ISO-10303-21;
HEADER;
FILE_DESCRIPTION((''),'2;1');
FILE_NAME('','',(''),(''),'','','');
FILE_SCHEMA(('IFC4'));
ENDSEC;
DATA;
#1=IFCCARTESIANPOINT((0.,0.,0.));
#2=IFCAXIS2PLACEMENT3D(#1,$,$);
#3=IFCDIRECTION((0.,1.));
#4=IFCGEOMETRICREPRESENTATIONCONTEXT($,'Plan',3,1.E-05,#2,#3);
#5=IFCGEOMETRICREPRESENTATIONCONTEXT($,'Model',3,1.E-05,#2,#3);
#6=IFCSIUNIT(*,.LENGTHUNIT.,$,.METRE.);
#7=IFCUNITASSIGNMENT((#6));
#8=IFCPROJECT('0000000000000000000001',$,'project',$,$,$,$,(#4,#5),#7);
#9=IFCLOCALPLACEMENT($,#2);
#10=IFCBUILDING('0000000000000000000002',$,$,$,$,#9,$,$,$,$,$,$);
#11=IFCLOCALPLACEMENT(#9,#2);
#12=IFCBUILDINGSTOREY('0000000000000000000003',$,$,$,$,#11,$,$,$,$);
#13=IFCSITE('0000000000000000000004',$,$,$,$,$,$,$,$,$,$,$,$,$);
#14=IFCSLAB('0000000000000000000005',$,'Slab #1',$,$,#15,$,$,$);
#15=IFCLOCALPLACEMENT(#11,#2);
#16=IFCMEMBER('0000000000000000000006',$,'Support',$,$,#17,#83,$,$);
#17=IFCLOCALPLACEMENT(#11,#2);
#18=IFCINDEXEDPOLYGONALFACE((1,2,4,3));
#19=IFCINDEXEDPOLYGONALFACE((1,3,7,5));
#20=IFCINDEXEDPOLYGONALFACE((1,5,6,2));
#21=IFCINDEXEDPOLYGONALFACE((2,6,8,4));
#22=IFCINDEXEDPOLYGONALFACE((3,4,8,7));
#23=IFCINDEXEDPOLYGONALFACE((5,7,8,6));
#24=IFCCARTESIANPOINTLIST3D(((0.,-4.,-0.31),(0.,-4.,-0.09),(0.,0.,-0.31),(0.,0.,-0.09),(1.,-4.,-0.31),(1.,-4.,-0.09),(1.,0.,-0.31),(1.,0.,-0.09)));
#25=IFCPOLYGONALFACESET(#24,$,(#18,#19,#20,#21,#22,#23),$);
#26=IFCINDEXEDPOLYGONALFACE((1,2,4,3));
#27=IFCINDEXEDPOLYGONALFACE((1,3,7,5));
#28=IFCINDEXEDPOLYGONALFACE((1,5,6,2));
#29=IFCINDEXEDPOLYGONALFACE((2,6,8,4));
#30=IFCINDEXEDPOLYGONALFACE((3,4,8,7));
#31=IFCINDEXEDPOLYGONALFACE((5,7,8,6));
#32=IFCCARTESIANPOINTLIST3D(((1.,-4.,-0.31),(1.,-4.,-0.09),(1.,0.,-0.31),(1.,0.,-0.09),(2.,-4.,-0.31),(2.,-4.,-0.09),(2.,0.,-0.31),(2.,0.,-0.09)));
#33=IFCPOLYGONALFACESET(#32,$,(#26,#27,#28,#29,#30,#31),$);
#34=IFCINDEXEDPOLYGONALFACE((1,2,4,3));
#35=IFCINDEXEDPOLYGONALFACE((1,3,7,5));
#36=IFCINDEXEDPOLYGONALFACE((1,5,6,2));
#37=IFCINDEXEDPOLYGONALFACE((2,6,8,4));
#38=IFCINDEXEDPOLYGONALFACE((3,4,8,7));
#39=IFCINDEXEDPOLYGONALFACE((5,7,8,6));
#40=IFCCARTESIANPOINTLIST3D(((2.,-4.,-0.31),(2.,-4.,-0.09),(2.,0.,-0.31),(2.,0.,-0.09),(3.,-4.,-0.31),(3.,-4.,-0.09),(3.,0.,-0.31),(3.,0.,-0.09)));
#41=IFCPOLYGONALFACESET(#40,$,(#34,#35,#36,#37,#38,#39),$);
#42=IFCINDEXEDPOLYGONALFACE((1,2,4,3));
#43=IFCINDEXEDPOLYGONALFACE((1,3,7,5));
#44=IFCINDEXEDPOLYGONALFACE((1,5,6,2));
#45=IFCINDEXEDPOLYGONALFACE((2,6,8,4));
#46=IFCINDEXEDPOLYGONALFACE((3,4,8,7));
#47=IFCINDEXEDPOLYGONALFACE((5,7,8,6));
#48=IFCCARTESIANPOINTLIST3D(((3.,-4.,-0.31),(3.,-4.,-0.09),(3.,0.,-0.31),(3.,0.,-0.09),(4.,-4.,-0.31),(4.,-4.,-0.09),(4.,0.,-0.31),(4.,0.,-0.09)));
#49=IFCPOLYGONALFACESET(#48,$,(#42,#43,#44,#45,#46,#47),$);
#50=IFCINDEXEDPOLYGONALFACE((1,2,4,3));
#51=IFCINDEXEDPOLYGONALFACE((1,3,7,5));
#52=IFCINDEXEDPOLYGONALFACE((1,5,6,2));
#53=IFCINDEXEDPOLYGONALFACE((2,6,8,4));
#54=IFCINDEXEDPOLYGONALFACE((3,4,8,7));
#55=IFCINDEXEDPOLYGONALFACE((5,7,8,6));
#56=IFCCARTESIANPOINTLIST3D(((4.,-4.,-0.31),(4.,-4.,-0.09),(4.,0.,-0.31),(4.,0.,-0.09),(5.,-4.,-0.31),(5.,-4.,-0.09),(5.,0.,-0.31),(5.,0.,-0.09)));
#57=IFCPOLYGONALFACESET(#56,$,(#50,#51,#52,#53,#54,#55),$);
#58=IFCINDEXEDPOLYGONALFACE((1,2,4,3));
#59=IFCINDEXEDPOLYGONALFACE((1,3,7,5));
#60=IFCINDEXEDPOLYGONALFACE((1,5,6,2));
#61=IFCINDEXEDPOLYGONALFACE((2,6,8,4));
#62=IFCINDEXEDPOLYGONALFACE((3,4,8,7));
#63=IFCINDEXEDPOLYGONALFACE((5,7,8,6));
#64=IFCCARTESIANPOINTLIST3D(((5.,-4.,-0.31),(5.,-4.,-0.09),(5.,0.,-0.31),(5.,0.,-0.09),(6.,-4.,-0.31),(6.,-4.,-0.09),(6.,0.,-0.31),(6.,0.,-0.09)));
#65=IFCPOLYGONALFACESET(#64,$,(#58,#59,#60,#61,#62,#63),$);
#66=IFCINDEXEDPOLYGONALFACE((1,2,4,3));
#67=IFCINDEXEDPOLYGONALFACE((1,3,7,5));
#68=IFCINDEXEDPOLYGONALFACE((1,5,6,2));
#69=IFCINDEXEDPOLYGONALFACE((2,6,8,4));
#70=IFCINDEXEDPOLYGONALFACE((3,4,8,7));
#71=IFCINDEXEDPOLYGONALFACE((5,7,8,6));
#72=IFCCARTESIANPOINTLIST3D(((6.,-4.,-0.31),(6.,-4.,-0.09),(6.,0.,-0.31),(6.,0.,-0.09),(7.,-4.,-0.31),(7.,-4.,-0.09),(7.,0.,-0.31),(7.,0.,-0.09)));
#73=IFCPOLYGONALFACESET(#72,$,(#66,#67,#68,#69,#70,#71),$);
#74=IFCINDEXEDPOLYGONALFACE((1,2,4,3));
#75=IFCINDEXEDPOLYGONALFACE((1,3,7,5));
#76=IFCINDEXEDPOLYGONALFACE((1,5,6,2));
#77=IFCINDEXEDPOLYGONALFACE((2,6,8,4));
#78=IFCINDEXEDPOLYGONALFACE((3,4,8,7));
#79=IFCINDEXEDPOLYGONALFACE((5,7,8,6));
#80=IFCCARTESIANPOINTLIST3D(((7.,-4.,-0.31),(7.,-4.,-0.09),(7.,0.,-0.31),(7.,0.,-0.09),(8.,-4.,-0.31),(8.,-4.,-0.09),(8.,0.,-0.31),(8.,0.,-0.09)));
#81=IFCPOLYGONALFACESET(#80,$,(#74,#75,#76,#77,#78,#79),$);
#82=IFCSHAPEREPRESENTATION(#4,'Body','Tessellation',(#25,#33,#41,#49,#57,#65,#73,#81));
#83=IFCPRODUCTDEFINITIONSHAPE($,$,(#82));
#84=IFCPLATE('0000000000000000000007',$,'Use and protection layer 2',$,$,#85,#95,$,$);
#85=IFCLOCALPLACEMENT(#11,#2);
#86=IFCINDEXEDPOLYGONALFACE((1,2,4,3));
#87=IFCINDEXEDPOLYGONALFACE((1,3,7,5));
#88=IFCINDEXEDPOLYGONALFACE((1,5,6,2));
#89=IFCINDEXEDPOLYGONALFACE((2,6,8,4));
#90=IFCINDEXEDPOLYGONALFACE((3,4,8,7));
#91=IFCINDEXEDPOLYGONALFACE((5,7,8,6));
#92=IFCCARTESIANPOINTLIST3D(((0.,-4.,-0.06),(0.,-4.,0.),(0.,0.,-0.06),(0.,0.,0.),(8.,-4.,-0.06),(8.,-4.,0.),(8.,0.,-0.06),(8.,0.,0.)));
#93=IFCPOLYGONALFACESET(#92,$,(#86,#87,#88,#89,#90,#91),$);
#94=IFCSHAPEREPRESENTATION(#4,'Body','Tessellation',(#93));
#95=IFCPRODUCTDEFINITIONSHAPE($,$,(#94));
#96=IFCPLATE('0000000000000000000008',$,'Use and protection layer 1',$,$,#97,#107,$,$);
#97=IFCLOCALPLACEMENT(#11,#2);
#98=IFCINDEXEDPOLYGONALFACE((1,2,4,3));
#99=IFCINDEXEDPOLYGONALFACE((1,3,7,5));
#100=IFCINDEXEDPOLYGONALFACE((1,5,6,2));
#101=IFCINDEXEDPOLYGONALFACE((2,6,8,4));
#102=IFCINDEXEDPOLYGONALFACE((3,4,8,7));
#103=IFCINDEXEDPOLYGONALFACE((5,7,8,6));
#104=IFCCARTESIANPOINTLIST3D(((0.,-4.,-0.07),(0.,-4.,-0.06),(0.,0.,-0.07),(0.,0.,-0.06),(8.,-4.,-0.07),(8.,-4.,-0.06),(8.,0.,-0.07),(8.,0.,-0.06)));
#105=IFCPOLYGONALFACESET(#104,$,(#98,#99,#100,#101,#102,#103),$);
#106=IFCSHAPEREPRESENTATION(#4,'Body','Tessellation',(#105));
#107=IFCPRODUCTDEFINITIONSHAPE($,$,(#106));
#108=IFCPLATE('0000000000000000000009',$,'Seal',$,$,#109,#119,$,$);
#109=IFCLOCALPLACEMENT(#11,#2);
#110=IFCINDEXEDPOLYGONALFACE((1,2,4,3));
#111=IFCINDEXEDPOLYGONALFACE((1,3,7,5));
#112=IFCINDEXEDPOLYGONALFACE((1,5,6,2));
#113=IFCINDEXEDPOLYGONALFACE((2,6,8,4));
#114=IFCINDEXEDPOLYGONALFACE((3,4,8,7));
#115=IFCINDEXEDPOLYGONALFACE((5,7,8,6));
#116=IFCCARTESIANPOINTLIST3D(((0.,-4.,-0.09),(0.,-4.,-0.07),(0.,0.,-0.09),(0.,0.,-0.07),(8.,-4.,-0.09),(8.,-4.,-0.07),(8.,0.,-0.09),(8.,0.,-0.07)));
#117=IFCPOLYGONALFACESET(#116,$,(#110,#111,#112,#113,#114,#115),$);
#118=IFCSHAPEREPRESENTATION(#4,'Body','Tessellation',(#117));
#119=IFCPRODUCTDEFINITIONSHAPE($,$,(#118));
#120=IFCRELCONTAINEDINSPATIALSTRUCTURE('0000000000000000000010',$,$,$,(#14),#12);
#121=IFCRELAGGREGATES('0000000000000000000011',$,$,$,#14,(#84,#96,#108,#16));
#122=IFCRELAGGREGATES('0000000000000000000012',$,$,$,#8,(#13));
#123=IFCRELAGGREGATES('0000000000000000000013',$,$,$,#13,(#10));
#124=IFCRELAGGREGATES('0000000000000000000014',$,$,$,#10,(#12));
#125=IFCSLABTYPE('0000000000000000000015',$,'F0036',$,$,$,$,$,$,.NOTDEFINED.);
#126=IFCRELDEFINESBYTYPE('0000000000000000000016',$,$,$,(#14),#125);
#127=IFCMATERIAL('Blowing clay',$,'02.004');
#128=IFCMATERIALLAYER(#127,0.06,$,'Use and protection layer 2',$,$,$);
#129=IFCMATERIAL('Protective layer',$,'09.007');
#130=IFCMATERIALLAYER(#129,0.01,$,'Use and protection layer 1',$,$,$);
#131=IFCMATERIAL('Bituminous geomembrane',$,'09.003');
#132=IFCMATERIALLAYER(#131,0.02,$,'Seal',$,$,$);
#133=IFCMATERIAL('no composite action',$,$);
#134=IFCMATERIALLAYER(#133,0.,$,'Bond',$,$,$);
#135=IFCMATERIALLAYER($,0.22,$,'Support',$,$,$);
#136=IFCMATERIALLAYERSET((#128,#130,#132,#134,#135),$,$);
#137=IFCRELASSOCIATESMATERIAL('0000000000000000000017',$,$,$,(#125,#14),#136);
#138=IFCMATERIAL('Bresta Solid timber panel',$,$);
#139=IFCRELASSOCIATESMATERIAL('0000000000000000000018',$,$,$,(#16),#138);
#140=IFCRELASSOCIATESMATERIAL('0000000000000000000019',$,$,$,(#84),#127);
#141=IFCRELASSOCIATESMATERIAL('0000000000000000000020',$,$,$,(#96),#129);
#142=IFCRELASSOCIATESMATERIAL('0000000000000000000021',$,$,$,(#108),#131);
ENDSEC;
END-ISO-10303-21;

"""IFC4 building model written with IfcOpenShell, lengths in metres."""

from ifc_helpers import new_model, si_unit, direction, frame, frame_2d, origin, origin_with_axes, place, context, project, spatial, rectangle, extrude, material, layer, layer_set, type_object, element, aggregate, save


model = new_model("IFC4")

# Units and contexts
plan_context = context("Plan", 3, precision=1e-05, world=origin(), true_north=direction((0.0, 1.0)))
model_context = context("Model", 3, precision=1e-05, world=origin(), true_north=direction((0.0, 1.0)))
ifc_project = project(units=[si_unit("LENGTHUNIT", "METRE")], contexts=[plan_context, model_context])

# Site, building, storey
site = spatial("IfcSite", under=ifc_project)
building_placement = place(None, origin())
building = spatial("IfcBuilding", under=site, at=building_placement)
storey_placement = place(building_placement, origin())
storey = spatial("IfcBuildingStorey", under=building, at=storey_placement)

# Slab, member, plates
ifc_material_1 = material(Name="Blowing clay", Category="02.004")
ifc_layer_1 = layer(ifc_material_1, 0.06, Name="Use and protection layer 2")
ifc_material_2 = material(Name="Protective layer", Category="09.007")
ifc_layer_2 = layer(ifc_material_2, 0.01, Name="Use and protection layer 1")
ifc_material_3 = material(Name="Bituminous geomembrane", Category="09.003")
ifc_layer_3 = layer(ifc_material_3, 0.02, Name="Seal")
ifc_material_4 = material(Name="no composite action")
ifc_layer_4 = layer(ifc_material_4, 0.0, Name="Bond")
ifc_layer_5 = layer(None, 0.22, Name="Support")
ifc_layer_set = layer_set([ifc_layer_1, ifc_layer_2, ifc_layer_3, ifc_layer_4, ifc_layer_5])
slab_type = type_object("IfcSlabType", Name="F0036", PredefinedType="NOTDEFINED", material=ifc_layer_set)
slab_placement = place(None, frame((0.0, 0.0, 0.0), z_axis=(0.0, 0.0, -1.0), x_axis=(1.0, 0.0, 0.0)))
slab = element("IfcSlab", 1, at=slab_placement, inside=storey, type_object=slab_type, material=ifc_layer_set, Name="Slab #1")
ifc_material_5 = material(Name="Bresta Solid timber panel")
member_placement = place(slab_placement, origin())
member = element("IfcMember", 2, at=member_placement, material=ifc_material_5, Name="Support", context=plan_context, shape_type="SweptSolid", body=[
    extrude(rectangle(XDim=1.0, YDim=0.22, at=frame_2d((0.5, 0.11), x_axis=(1.0, 0.0))), frame((0.0, 4.0, 0.09), z_axis=(0.0, -1.0, 0.0), x_axis=(1.0, 0.0, 0.0)), (0.0, 0.0, 1.0), 4.0),
    extrude(rectangle(XDim=1.0, YDim=0.22, at=frame_2d((0.5, 0.11), x_axis=(1.0, 0.0))), frame((1.0, 4.0, 0.09), z_axis=(0.0, -1.0, 0.0), x_axis=(1.0, 0.0, 0.0)), (0.0, 0.0, 1.0), 4.0),
    extrude(rectangle(XDim=1.0, YDim=0.22, at=frame_2d((0.5, 0.11), x_axis=(1.0, 0.0))), frame((2.0, 4.0, 0.09), z_axis=(0.0, -1.0, 0.0), x_axis=(1.0, 0.0, 0.0)), (0.0, 0.0, 1.0), 4.0),
    extrude(rectangle(XDim=1.0, YDim=0.22, at=frame_2d((0.5, 0.11), x_axis=(1.0, 0.0))), frame((3.0, 4.0, 0.09), z_axis=(0.0, -1.0, 0.0), x_axis=(1.0, 0.0, 0.0)), (0.0, 0.0, 1.0), 4.0),
    extrude(rectangle(XDim=1.0, YDim=0.22, at=frame_2d((0.5, 0.11), x_axis=(1.0, 0.0))), frame((4.0, 4.0, 0.09), z_axis=(0.0, -1.0, 0.0), x_axis=(1.0, 0.0, 0.0)), (0.0, 0.0, 1.0), 4.0),
    extrude(rectangle(XDim=1.0, YDim=0.22, at=frame_2d((0.5, 0.11), x_axis=(1.0, 0.0))), frame((5.0, 4.0, 0.09), z_axis=(0.0, -1.0, 0.0), x_axis=(1.0, 0.0, 0.0)), (0.0, 0.0, 1.0), 4.0),
    extrude(rectangle(XDim=1.0, YDim=0.22, at=frame_2d((0.5, 0.11), x_axis=(1.0, 0.0))), frame((6.0, 4.0, 0.09), z_axis=(0.0, -1.0, 0.0), x_axis=(1.0, 0.0, 0.0)), (0.0, 0.0, 1.0), 4.0),
    extrude(rectangle(XDim=1.0, YDim=0.22, at=frame_2d((0.5, 0.11), x_axis=(1.0, 0.0))), frame((7.0, 4.0, 0.09), z_axis=(0.0, -1.0, 0.0), x_axis=(1.0, 0.0, 0.0)), (0.0, 0.0, 1.0), 4.0),
])
plate_1_placement = place(slab_placement, origin())
plate_1 = element("IfcPlate", 3, at=plate_1_placement, material=ifc_material_1, Name="Use and protection layer 2", context=plan_context, shape_type="SweptSolid", body=[
    extrude(rectangle(XDim=8.0, YDim=4.0, at=frame_2d((4.0, 2.0), x_axis=(1.0, 0.0))), origin_with_axes(), (0.0, 0.0, 1.0), 0.06),
])
plate_2_placement = place(slab_placement, origin())
plate_2 = element("IfcPlate", 4, at=plate_2_placement, material=ifc_material_2, Name="Use and protection layer 1", context=plan_context, shape_type="SweptSolid", body=[
    extrude(rectangle(XDim=8.0, YDim=4.0, at=frame_2d((4.0, 2.0), x_axis=(1.0, 0.0))), frame((0.0, 0.0, 0.06), z_axis=(0.0, 0.0, 1.0), x_axis=(1.0, 0.0, 0.0)), (0.0, 0.0, 1.0), 0.01),
])
plate_3_placement = place(slab_placement, origin())
plate_3 = element("IfcPlate", 5, at=plate_3_placement, material=ifc_material_3, Name="Seal", context=plan_context, shape_type="SweptSolid", body=[
    extrude(rectangle(XDim=8.0, YDim=4.0, at=frame_2d((4.0, 2.0), x_axis=(1.0, 0.0))), frame((0.0, 0.0, 0.07), z_axis=(0.0, 0.0, 1.0), x_axis=(1.0, 0.0, 0.0)), (0.0, 0.0, 1.0), 0.02),
])
aggregate(slab, [plate_1, plate_2, plate_3, member])

save(model, "model.ifc")
